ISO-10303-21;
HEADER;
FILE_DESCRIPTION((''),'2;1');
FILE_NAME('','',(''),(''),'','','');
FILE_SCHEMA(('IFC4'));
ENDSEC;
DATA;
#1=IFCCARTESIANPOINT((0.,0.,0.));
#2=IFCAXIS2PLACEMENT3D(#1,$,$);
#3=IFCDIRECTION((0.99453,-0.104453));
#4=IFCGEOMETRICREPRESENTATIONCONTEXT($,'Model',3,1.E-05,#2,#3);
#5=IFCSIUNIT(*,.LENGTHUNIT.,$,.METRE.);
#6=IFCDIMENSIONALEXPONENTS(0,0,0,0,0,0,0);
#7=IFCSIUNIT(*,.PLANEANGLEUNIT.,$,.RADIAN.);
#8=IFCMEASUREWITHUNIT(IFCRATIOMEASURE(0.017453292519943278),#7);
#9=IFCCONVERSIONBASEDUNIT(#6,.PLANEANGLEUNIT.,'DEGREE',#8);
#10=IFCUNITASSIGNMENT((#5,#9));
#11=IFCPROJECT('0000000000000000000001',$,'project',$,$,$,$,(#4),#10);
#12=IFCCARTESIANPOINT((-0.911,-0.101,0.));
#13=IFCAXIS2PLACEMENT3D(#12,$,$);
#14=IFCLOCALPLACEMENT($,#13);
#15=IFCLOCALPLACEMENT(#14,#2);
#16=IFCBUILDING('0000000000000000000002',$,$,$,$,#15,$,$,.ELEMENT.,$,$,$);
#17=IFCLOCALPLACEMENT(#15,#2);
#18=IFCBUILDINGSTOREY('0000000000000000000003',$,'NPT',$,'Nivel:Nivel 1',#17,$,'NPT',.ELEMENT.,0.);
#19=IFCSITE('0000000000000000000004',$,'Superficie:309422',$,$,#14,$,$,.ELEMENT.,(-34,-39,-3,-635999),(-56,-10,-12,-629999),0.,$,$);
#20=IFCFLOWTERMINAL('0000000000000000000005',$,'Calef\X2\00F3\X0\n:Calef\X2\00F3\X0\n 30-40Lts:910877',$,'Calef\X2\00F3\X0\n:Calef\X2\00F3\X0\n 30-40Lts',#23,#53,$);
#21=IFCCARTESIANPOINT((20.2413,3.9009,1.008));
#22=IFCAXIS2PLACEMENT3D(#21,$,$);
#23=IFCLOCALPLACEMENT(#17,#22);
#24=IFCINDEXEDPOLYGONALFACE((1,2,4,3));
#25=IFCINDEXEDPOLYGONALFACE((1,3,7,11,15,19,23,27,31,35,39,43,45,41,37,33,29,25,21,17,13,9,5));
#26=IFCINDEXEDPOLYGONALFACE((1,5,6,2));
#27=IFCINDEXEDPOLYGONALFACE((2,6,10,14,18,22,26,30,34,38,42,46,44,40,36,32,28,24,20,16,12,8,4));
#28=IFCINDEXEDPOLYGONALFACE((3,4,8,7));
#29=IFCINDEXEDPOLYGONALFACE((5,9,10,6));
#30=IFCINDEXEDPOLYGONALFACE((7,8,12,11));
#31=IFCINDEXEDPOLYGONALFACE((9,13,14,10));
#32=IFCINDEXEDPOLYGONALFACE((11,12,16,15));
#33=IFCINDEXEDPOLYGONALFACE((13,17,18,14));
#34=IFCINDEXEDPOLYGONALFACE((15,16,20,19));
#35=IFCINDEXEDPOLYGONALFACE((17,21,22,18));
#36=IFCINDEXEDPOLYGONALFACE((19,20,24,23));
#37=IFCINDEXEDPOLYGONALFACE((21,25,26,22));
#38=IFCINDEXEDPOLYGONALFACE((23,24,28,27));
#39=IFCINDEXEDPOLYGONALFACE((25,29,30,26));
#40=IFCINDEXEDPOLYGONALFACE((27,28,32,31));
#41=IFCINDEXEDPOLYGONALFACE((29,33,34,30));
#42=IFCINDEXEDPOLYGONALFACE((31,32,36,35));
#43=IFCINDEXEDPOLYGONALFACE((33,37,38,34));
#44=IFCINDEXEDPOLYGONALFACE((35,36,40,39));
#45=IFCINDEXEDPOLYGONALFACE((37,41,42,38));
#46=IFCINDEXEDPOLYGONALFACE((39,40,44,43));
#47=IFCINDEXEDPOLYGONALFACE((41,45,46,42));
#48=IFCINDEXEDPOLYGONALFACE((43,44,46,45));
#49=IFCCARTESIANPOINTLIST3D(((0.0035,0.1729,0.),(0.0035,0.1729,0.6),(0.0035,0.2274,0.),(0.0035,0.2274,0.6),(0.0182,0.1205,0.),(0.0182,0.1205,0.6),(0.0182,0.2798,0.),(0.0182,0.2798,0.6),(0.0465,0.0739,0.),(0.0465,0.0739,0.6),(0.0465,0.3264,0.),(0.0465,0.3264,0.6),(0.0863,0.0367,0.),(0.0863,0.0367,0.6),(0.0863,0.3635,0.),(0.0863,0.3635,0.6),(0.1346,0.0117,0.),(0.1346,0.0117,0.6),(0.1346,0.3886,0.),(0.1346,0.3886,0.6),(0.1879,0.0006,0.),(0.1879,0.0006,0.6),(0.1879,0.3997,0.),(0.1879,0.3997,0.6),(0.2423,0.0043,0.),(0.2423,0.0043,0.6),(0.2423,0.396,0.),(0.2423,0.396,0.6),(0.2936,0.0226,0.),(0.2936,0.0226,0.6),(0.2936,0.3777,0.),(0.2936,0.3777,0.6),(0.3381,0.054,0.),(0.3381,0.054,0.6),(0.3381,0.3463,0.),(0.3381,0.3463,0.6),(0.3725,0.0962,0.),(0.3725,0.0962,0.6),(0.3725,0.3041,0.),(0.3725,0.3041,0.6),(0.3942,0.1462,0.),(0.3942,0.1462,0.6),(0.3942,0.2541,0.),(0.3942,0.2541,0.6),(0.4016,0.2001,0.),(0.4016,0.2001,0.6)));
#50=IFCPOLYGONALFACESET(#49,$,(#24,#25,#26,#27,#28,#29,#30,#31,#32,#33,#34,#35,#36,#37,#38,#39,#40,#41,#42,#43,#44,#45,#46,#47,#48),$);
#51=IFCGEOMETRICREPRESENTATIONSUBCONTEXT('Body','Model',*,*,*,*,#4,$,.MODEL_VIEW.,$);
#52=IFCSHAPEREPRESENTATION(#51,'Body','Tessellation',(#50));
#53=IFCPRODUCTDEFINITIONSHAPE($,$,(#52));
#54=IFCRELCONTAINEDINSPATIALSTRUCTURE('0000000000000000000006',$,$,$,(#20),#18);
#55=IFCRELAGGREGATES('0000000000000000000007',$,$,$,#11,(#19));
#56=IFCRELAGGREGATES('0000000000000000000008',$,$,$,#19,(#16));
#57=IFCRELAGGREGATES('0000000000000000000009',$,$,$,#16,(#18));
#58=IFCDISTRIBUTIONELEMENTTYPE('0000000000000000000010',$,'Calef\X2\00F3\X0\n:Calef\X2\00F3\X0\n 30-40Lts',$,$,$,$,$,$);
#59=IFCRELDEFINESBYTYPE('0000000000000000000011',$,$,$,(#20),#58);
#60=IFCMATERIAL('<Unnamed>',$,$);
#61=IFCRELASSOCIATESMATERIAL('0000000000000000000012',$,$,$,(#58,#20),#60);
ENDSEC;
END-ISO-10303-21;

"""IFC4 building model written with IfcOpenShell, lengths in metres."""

from ifc_helpers import new_model, entity, si_unit, converted_unit, direction, frame, frame_2d, origin, place, context, subcontext, project, spatial, circle, extrude, source, transform, mapped, material, type_object, type_shapes, element, save


model = new_model("IFC4")

# Units and contexts
model_context = context("Model", 3, precision=1e-05, world=origin(), true_north=direction((0.99453, -0.104453)))
body_context = subcontext(model_context, "Body", "Model", "MODEL_VIEW")
ifc_project = project(units=[si_unit("LENGTHUNIT", "METRE"), converted_unit("PLANEANGLEUNIT", "DEGREE", entity("IfcRatioMeasure", 0.017453292519943278), si_unit("PLANEANGLEUNIT", "RADIAN"), dimensions=[0, 0, 0, 0, 0, 0, 0])], contexts=[model_context])

# Site, building, storey
site_placement = place(None, frame((-0.911, -0.101, 0.0)))
site = spatial("IfcSite", under=ifc_project, at=site_placement, Name="Superficie:309422", CompositionType="ELEMENT", RefLatitude=(-34, -39, -3, -635999), RefLongitude=(-56, -10, -12, -629999), RefElevation=0.0)
building_placement = place(site_placement, origin())
building = spatial("IfcBuilding", under=site, at=building_placement, CompositionType="ELEMENT")
storey_placement = place(building_placement, origin())
storey = spatial("IfcBuildingStorey", under=building, at=storey_placement, Name="NPT", ObjectType="Nivel:Nivel 1", LongName="NPT", CompositionType="ELEMENT", Elevation=0.0)

# Flow terminal
ifc_material_1 = material(Name="<Unnamed>")
distribution_element_type_1 = type_object("IfcDistributionElementType", Name="Calefón:Calefón 30-40Lts", material=ifc_material_1)
shared_shape_1 = source(origin(), body_context, "Body", "SweptSolid", [
    extrude(circle(Radius=0.2, at=frame_2d((0.0, 0.0), x_axis=(1.0, 0.0))), frame((0.2016, 0.2001, 0.0)), (0.0, 0.0, 1.0), 0.6),
])
type_shapes(distribution_element_type_1, [shared_shape_1])
flow_terminal_1_placement = place(storey_placement, frame((20.2413, 3.9009, 1.008)))
element("IfcFlowTerminal", 1, at=flow_terminal_1_placement, inside=storey, type_object=distribution_element_type_1, material=ifc_material_1, Name="Calefón:Calefón 30-40Lts:910877", ObjectType="Calefón:Calefón 30-40Lts", context=body_context, shape_type="MappedRepresentation", body=[
    mapped(shared_shape_1, transform((0.0, 0.0, 0.0), scale=1.0)),
])

save(model, "model.ifc")
